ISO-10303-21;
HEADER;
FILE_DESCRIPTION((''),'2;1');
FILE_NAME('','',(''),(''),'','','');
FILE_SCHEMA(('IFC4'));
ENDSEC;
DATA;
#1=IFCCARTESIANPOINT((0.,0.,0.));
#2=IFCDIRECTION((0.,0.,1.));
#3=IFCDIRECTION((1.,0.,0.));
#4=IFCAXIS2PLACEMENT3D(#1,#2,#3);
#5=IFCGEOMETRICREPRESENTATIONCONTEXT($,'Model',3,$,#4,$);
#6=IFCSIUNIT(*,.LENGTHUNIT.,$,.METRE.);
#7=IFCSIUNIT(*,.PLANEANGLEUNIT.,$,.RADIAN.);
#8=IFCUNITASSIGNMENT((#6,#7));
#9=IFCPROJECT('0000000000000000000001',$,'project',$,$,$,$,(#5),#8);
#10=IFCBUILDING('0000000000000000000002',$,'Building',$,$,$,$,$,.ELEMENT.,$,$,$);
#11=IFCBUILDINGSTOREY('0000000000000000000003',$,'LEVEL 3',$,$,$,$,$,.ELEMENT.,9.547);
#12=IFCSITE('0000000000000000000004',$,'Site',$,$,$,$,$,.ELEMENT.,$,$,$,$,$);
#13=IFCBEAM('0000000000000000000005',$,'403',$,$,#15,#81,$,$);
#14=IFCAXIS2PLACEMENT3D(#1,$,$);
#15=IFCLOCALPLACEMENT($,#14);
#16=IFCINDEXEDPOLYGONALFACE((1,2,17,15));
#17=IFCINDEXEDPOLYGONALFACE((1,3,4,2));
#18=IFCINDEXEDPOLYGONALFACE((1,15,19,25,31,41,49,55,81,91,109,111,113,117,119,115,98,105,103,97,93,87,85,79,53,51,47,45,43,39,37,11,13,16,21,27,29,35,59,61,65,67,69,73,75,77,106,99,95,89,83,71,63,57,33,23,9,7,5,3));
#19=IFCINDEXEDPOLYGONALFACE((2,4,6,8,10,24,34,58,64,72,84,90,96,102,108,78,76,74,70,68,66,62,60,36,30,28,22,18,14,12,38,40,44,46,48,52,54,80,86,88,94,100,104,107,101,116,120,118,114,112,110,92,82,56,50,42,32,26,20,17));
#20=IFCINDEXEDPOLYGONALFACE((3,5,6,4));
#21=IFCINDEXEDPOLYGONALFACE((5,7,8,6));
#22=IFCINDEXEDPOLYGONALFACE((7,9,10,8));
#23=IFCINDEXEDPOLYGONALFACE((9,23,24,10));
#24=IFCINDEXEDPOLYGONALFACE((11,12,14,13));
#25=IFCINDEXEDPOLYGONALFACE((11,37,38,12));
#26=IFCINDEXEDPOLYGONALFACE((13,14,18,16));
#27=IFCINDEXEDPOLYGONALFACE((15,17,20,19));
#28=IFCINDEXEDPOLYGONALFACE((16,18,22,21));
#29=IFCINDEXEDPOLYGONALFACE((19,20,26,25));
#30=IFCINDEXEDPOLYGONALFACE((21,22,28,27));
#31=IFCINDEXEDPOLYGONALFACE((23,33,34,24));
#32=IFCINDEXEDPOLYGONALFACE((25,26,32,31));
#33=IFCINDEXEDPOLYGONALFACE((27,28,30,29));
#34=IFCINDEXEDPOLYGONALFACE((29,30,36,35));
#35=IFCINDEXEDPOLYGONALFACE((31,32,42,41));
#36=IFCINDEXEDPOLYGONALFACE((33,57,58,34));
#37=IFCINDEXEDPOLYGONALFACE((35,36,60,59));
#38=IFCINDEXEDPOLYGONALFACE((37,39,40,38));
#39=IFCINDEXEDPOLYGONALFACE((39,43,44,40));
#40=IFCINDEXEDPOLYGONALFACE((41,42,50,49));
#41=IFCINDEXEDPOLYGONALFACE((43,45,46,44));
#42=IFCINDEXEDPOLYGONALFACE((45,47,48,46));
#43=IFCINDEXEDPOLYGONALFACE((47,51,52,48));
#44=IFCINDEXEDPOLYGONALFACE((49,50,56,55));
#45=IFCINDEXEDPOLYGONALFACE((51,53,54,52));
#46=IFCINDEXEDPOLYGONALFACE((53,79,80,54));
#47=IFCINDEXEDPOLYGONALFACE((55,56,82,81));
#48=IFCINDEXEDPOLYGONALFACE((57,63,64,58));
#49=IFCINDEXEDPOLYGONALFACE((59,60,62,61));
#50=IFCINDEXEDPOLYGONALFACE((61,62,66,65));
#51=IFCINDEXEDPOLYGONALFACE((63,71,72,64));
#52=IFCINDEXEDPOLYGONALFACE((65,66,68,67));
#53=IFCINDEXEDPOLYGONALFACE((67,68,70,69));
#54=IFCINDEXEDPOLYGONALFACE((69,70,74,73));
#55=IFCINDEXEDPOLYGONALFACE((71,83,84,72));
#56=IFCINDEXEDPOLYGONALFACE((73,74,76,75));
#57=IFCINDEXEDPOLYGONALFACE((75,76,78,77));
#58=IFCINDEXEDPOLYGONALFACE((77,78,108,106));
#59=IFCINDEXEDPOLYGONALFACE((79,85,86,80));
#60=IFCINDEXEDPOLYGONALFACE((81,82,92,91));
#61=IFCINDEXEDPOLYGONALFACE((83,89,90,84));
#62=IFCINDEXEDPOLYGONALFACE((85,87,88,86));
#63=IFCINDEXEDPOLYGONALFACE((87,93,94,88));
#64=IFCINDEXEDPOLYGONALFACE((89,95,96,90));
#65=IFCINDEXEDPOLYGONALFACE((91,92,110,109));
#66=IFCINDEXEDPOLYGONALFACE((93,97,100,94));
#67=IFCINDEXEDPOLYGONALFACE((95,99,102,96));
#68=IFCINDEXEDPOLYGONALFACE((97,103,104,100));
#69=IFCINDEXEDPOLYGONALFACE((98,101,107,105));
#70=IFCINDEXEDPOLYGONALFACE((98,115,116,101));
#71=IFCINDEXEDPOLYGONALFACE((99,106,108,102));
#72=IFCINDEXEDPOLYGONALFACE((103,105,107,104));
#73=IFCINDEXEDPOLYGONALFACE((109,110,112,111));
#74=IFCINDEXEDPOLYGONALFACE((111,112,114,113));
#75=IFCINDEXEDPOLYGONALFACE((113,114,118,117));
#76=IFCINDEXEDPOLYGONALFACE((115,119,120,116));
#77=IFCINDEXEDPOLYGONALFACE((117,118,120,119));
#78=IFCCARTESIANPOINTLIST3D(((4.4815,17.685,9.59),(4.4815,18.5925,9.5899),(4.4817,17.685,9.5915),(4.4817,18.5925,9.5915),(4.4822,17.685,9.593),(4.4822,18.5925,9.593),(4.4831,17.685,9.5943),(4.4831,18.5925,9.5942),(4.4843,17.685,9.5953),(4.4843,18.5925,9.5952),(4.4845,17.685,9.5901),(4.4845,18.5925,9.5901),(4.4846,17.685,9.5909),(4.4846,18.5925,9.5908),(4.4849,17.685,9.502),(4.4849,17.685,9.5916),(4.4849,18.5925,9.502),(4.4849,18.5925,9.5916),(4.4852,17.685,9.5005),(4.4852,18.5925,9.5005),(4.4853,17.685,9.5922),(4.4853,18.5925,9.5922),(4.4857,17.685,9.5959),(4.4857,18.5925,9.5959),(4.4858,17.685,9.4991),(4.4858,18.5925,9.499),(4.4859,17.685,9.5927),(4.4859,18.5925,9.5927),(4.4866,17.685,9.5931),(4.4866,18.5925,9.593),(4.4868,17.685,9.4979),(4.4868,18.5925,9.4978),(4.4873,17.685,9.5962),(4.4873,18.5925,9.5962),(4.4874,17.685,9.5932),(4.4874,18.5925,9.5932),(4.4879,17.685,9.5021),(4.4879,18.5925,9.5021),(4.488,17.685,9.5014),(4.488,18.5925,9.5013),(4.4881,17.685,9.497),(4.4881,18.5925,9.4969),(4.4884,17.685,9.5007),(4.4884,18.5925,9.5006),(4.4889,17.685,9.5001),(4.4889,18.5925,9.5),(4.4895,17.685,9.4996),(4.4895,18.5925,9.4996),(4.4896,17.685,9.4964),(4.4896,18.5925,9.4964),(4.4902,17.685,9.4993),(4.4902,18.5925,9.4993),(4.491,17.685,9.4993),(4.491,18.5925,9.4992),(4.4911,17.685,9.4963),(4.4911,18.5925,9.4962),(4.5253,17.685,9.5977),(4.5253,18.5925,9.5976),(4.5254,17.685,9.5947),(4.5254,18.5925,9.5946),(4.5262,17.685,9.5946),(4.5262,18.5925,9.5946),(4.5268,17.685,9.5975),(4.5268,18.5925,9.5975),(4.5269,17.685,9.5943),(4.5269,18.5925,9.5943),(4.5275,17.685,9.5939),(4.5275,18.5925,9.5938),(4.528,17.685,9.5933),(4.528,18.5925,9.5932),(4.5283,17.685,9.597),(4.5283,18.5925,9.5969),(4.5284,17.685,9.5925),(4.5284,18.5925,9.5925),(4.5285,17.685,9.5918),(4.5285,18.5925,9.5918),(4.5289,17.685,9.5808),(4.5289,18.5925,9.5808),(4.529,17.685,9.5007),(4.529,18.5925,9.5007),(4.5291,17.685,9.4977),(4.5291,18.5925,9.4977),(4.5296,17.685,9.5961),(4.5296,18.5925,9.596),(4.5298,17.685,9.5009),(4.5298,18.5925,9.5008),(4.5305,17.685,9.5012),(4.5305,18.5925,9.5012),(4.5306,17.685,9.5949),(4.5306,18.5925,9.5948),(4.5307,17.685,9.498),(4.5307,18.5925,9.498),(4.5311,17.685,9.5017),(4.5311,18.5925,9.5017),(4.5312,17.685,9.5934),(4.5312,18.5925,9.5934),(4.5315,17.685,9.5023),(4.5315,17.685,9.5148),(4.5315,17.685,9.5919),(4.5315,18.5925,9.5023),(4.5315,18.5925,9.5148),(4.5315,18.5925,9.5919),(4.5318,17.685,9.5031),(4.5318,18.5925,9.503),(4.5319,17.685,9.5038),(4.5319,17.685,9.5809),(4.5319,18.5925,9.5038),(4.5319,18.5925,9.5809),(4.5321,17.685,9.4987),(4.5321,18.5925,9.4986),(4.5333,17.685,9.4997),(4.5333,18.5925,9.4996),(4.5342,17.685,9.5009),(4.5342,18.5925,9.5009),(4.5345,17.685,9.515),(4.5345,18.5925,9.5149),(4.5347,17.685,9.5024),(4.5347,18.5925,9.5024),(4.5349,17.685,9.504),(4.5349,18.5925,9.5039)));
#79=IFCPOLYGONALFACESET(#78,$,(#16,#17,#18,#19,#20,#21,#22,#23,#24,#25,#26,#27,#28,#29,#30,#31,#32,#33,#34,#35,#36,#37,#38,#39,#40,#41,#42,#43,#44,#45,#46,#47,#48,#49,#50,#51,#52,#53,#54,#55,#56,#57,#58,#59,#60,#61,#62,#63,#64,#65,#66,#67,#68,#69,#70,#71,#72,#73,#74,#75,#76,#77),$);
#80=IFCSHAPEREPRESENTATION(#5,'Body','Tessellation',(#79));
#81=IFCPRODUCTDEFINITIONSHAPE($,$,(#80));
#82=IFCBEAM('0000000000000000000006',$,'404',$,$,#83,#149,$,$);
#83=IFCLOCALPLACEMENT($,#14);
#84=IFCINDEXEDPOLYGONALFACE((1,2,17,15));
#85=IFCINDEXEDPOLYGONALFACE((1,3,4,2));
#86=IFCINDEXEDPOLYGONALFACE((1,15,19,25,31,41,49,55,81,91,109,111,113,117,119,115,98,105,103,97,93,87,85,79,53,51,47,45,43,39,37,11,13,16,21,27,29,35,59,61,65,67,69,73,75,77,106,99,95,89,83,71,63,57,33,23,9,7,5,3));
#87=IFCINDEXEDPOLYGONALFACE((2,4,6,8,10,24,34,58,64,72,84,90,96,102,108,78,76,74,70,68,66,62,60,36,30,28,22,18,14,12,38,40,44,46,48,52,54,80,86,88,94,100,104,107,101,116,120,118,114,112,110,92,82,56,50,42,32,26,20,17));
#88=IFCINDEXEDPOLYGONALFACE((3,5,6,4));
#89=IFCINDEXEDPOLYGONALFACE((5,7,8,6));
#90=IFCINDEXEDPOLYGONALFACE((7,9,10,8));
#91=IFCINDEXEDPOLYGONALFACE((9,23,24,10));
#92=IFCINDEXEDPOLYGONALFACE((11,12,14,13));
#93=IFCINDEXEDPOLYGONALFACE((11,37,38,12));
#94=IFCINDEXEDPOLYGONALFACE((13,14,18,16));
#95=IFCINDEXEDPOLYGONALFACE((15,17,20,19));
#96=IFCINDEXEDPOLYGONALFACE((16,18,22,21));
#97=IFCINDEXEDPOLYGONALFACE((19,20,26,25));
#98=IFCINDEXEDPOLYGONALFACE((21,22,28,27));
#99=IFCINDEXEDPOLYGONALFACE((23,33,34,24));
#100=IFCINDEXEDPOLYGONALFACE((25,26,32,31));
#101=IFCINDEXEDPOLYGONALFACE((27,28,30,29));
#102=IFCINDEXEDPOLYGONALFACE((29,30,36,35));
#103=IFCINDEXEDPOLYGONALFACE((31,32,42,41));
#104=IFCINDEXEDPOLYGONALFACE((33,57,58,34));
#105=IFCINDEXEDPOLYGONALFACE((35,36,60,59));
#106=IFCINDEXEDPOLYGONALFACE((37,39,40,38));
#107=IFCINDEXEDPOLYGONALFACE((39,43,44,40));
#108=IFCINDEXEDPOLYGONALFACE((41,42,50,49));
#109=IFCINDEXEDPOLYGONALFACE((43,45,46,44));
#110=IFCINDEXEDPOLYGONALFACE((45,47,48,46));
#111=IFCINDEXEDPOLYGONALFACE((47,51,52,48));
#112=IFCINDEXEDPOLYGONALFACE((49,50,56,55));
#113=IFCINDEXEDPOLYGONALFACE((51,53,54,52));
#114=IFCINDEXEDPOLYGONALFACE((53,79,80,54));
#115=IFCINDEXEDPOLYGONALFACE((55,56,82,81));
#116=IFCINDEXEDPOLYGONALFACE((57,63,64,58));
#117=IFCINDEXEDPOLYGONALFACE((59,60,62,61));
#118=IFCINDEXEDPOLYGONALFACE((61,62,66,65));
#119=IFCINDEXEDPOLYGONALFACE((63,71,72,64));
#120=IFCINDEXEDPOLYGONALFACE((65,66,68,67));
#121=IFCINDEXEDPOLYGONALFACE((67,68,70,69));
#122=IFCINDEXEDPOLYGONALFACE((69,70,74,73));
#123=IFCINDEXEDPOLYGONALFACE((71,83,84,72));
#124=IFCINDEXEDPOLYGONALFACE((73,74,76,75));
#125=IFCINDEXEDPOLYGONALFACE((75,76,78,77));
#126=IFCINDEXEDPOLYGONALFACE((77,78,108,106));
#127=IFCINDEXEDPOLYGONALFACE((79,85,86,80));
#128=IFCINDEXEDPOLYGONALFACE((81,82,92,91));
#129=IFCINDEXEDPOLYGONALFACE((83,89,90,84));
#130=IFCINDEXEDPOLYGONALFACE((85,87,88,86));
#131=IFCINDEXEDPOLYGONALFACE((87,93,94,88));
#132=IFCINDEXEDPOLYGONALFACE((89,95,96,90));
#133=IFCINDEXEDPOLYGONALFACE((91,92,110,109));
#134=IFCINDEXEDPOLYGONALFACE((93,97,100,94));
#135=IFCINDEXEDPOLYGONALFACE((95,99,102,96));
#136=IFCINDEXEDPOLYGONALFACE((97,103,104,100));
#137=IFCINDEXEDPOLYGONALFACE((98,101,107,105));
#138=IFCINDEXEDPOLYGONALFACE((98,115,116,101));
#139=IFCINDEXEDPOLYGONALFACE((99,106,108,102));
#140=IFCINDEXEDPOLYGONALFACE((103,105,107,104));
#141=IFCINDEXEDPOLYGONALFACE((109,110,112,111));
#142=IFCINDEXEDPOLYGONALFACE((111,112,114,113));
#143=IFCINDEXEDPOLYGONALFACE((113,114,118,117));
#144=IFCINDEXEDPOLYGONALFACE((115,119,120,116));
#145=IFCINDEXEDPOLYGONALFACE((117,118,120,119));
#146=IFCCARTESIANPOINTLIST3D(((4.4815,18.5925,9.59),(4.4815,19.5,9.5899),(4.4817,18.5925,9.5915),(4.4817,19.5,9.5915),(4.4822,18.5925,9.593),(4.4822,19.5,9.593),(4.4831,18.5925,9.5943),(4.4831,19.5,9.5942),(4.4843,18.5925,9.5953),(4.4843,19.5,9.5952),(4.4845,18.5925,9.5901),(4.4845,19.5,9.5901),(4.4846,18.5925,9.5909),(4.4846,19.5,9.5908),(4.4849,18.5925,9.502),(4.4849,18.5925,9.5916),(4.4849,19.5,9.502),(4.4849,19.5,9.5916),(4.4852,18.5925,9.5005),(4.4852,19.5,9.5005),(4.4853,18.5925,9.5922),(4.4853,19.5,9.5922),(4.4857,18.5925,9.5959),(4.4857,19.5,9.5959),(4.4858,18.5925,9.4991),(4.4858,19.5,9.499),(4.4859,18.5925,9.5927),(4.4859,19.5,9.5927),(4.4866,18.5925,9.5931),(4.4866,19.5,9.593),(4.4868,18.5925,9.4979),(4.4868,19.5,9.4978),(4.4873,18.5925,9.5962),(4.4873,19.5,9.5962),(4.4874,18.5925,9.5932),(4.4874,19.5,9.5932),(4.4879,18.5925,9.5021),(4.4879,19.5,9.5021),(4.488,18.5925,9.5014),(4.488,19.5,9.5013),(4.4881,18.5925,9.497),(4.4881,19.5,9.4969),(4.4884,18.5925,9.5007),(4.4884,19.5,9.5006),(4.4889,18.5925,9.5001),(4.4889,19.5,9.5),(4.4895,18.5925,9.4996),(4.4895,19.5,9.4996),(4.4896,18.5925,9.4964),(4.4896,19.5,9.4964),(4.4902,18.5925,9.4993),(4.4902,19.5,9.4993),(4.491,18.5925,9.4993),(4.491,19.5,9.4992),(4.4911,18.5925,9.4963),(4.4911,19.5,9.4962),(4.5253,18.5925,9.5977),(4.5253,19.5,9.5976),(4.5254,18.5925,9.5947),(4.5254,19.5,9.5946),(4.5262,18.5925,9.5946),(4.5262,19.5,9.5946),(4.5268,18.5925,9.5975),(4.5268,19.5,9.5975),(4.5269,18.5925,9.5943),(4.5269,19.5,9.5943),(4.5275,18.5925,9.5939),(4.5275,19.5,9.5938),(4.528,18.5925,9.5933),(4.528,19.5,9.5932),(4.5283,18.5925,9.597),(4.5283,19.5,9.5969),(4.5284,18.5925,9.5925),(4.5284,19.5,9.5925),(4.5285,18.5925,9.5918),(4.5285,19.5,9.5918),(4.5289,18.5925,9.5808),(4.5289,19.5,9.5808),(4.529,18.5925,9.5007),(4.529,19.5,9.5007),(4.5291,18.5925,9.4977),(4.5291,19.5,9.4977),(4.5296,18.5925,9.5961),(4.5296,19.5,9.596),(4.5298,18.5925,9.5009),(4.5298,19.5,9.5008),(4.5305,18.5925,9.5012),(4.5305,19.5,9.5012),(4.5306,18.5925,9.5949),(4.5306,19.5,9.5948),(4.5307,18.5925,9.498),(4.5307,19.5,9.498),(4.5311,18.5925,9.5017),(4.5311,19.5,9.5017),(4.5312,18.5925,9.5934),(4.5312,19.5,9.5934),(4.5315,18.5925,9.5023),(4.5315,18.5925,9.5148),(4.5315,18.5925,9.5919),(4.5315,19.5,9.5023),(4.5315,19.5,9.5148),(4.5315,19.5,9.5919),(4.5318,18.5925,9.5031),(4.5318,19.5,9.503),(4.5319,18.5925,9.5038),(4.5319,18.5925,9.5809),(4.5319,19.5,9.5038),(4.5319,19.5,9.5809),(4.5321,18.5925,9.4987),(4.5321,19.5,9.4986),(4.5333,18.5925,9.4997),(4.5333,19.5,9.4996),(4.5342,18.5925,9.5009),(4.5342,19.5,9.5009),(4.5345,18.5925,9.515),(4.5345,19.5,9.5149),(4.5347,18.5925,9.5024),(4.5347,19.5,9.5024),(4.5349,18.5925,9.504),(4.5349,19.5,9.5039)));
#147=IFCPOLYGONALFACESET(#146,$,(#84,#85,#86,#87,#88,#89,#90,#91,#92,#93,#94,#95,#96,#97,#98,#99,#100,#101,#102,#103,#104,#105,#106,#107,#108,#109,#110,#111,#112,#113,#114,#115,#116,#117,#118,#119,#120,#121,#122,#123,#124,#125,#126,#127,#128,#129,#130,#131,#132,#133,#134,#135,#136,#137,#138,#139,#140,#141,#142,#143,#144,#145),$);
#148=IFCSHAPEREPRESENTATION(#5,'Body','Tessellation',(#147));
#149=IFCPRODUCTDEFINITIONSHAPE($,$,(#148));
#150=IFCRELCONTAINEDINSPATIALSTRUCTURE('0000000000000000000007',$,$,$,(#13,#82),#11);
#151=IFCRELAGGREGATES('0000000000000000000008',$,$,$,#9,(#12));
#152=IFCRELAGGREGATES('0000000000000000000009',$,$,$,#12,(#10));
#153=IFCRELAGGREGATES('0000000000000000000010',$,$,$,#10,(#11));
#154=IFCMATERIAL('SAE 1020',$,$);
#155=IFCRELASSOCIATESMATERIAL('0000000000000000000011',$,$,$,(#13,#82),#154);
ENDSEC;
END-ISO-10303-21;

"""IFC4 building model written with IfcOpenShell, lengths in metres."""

from ifc_helpers import new_model, si_unit, frame, origin_with_axes, origin_2d_with_axis, place, context, project, spatial, c_section, extrude, material, material_profile, profile_set, profile_usage, element, save


model = new_model("IFC4")

# Units and contexts
model_context = context("Model", 3, world=origin_with_axes())
ifc_project = project(units=[si_unit("LENGTHUNIT", "METRE"), si_unit("PLANEANGLEUNIT", "RADIAN")], contexts=[model_context])

# Site, building, storey
site = spatial("IfcSite", under=ifc_project, Name="Site", CompositionType="ELEMENT")
building = spatial("IfcBuilding", under=site, Name="Building", CompositionType="ELEMENT")
storey = spatial("IfcBuildingStorey", under=building, Name="LEVEL 3", CompositionType="ELEMENT", Elevation=9.547)

# Beams
ifc_material = material(Name="SAE 1020")
ifc_material_profile_1 = material_profile(ifc_material, c_section(Depth=0.1, Width=0.05, WallThickness=0.003, Girth=0.017, InternalFilletRadius=0.003, at=origin_2d_with_axis()))
ifc_profile_set_1 = profile_set([ifc_material_profile_1])
ifc_profile_usage_1 = profile_usage(ifc_profile_set_1, cardinal=10)
beam_1_placement = place(None, frame((4.5082, 17.685, 9.547), z_axis=(0.0, 1.0, -0.00003), x_axis=(0.999256, 0.000001, 0.038562)))
element("IfcBeam", 1, at=beam_1_placement, inside=storey, material=ifc_profile_usage_1, Name="403", context=model_context, shape_type="SweptSolid", body=[
    extrude(c_section(Depth=0.1, Width=0.05, WallThickness=0.003, Girth=0.017, InternalFilletRadius=0.003, at=origin_2d_with_axis()), origin_with_axes(), (0.0, 0.0, 1.0), 0.9075),
])
ifc_material_profile_2 = material_profile(ifc_material, c_section(Depth=0.1, Width=0.05, WallThickness=0.003, Girth=0.017, InternalFilletRadius=0.003, at=origin_2d_with_axis()))
ifc_profile_set_2 = profile_set([ifc_material_profile_2])
ifc_profile_usage_2 = profile_usage(ifc_profile_set_2, cardinal=10)
beam_2_placement = place(None, frame((4.5082, 18.5925, 9.547), z_axis=(0.0, 1.0, -0.00003), x_axis=(0.999256, 0.000001, 0.038562)))
element("IfcBeam", 2, at=beam_2_placement, inside=storey, material=ifc_profile_usage_2, Name="404", context=model_context, shape_type="SweptSolid", body=[
    extrude(c_section(Depth=0.1, Width=0.05, WallThickness=0.003, Girth=0.017, InternalFilletRadius=0.003, at=origin_2d_with_axis()), origin_with_axes(), (0.0, 0.0, 1.0), 0.9075),
])

save(model, "model.ifc")
